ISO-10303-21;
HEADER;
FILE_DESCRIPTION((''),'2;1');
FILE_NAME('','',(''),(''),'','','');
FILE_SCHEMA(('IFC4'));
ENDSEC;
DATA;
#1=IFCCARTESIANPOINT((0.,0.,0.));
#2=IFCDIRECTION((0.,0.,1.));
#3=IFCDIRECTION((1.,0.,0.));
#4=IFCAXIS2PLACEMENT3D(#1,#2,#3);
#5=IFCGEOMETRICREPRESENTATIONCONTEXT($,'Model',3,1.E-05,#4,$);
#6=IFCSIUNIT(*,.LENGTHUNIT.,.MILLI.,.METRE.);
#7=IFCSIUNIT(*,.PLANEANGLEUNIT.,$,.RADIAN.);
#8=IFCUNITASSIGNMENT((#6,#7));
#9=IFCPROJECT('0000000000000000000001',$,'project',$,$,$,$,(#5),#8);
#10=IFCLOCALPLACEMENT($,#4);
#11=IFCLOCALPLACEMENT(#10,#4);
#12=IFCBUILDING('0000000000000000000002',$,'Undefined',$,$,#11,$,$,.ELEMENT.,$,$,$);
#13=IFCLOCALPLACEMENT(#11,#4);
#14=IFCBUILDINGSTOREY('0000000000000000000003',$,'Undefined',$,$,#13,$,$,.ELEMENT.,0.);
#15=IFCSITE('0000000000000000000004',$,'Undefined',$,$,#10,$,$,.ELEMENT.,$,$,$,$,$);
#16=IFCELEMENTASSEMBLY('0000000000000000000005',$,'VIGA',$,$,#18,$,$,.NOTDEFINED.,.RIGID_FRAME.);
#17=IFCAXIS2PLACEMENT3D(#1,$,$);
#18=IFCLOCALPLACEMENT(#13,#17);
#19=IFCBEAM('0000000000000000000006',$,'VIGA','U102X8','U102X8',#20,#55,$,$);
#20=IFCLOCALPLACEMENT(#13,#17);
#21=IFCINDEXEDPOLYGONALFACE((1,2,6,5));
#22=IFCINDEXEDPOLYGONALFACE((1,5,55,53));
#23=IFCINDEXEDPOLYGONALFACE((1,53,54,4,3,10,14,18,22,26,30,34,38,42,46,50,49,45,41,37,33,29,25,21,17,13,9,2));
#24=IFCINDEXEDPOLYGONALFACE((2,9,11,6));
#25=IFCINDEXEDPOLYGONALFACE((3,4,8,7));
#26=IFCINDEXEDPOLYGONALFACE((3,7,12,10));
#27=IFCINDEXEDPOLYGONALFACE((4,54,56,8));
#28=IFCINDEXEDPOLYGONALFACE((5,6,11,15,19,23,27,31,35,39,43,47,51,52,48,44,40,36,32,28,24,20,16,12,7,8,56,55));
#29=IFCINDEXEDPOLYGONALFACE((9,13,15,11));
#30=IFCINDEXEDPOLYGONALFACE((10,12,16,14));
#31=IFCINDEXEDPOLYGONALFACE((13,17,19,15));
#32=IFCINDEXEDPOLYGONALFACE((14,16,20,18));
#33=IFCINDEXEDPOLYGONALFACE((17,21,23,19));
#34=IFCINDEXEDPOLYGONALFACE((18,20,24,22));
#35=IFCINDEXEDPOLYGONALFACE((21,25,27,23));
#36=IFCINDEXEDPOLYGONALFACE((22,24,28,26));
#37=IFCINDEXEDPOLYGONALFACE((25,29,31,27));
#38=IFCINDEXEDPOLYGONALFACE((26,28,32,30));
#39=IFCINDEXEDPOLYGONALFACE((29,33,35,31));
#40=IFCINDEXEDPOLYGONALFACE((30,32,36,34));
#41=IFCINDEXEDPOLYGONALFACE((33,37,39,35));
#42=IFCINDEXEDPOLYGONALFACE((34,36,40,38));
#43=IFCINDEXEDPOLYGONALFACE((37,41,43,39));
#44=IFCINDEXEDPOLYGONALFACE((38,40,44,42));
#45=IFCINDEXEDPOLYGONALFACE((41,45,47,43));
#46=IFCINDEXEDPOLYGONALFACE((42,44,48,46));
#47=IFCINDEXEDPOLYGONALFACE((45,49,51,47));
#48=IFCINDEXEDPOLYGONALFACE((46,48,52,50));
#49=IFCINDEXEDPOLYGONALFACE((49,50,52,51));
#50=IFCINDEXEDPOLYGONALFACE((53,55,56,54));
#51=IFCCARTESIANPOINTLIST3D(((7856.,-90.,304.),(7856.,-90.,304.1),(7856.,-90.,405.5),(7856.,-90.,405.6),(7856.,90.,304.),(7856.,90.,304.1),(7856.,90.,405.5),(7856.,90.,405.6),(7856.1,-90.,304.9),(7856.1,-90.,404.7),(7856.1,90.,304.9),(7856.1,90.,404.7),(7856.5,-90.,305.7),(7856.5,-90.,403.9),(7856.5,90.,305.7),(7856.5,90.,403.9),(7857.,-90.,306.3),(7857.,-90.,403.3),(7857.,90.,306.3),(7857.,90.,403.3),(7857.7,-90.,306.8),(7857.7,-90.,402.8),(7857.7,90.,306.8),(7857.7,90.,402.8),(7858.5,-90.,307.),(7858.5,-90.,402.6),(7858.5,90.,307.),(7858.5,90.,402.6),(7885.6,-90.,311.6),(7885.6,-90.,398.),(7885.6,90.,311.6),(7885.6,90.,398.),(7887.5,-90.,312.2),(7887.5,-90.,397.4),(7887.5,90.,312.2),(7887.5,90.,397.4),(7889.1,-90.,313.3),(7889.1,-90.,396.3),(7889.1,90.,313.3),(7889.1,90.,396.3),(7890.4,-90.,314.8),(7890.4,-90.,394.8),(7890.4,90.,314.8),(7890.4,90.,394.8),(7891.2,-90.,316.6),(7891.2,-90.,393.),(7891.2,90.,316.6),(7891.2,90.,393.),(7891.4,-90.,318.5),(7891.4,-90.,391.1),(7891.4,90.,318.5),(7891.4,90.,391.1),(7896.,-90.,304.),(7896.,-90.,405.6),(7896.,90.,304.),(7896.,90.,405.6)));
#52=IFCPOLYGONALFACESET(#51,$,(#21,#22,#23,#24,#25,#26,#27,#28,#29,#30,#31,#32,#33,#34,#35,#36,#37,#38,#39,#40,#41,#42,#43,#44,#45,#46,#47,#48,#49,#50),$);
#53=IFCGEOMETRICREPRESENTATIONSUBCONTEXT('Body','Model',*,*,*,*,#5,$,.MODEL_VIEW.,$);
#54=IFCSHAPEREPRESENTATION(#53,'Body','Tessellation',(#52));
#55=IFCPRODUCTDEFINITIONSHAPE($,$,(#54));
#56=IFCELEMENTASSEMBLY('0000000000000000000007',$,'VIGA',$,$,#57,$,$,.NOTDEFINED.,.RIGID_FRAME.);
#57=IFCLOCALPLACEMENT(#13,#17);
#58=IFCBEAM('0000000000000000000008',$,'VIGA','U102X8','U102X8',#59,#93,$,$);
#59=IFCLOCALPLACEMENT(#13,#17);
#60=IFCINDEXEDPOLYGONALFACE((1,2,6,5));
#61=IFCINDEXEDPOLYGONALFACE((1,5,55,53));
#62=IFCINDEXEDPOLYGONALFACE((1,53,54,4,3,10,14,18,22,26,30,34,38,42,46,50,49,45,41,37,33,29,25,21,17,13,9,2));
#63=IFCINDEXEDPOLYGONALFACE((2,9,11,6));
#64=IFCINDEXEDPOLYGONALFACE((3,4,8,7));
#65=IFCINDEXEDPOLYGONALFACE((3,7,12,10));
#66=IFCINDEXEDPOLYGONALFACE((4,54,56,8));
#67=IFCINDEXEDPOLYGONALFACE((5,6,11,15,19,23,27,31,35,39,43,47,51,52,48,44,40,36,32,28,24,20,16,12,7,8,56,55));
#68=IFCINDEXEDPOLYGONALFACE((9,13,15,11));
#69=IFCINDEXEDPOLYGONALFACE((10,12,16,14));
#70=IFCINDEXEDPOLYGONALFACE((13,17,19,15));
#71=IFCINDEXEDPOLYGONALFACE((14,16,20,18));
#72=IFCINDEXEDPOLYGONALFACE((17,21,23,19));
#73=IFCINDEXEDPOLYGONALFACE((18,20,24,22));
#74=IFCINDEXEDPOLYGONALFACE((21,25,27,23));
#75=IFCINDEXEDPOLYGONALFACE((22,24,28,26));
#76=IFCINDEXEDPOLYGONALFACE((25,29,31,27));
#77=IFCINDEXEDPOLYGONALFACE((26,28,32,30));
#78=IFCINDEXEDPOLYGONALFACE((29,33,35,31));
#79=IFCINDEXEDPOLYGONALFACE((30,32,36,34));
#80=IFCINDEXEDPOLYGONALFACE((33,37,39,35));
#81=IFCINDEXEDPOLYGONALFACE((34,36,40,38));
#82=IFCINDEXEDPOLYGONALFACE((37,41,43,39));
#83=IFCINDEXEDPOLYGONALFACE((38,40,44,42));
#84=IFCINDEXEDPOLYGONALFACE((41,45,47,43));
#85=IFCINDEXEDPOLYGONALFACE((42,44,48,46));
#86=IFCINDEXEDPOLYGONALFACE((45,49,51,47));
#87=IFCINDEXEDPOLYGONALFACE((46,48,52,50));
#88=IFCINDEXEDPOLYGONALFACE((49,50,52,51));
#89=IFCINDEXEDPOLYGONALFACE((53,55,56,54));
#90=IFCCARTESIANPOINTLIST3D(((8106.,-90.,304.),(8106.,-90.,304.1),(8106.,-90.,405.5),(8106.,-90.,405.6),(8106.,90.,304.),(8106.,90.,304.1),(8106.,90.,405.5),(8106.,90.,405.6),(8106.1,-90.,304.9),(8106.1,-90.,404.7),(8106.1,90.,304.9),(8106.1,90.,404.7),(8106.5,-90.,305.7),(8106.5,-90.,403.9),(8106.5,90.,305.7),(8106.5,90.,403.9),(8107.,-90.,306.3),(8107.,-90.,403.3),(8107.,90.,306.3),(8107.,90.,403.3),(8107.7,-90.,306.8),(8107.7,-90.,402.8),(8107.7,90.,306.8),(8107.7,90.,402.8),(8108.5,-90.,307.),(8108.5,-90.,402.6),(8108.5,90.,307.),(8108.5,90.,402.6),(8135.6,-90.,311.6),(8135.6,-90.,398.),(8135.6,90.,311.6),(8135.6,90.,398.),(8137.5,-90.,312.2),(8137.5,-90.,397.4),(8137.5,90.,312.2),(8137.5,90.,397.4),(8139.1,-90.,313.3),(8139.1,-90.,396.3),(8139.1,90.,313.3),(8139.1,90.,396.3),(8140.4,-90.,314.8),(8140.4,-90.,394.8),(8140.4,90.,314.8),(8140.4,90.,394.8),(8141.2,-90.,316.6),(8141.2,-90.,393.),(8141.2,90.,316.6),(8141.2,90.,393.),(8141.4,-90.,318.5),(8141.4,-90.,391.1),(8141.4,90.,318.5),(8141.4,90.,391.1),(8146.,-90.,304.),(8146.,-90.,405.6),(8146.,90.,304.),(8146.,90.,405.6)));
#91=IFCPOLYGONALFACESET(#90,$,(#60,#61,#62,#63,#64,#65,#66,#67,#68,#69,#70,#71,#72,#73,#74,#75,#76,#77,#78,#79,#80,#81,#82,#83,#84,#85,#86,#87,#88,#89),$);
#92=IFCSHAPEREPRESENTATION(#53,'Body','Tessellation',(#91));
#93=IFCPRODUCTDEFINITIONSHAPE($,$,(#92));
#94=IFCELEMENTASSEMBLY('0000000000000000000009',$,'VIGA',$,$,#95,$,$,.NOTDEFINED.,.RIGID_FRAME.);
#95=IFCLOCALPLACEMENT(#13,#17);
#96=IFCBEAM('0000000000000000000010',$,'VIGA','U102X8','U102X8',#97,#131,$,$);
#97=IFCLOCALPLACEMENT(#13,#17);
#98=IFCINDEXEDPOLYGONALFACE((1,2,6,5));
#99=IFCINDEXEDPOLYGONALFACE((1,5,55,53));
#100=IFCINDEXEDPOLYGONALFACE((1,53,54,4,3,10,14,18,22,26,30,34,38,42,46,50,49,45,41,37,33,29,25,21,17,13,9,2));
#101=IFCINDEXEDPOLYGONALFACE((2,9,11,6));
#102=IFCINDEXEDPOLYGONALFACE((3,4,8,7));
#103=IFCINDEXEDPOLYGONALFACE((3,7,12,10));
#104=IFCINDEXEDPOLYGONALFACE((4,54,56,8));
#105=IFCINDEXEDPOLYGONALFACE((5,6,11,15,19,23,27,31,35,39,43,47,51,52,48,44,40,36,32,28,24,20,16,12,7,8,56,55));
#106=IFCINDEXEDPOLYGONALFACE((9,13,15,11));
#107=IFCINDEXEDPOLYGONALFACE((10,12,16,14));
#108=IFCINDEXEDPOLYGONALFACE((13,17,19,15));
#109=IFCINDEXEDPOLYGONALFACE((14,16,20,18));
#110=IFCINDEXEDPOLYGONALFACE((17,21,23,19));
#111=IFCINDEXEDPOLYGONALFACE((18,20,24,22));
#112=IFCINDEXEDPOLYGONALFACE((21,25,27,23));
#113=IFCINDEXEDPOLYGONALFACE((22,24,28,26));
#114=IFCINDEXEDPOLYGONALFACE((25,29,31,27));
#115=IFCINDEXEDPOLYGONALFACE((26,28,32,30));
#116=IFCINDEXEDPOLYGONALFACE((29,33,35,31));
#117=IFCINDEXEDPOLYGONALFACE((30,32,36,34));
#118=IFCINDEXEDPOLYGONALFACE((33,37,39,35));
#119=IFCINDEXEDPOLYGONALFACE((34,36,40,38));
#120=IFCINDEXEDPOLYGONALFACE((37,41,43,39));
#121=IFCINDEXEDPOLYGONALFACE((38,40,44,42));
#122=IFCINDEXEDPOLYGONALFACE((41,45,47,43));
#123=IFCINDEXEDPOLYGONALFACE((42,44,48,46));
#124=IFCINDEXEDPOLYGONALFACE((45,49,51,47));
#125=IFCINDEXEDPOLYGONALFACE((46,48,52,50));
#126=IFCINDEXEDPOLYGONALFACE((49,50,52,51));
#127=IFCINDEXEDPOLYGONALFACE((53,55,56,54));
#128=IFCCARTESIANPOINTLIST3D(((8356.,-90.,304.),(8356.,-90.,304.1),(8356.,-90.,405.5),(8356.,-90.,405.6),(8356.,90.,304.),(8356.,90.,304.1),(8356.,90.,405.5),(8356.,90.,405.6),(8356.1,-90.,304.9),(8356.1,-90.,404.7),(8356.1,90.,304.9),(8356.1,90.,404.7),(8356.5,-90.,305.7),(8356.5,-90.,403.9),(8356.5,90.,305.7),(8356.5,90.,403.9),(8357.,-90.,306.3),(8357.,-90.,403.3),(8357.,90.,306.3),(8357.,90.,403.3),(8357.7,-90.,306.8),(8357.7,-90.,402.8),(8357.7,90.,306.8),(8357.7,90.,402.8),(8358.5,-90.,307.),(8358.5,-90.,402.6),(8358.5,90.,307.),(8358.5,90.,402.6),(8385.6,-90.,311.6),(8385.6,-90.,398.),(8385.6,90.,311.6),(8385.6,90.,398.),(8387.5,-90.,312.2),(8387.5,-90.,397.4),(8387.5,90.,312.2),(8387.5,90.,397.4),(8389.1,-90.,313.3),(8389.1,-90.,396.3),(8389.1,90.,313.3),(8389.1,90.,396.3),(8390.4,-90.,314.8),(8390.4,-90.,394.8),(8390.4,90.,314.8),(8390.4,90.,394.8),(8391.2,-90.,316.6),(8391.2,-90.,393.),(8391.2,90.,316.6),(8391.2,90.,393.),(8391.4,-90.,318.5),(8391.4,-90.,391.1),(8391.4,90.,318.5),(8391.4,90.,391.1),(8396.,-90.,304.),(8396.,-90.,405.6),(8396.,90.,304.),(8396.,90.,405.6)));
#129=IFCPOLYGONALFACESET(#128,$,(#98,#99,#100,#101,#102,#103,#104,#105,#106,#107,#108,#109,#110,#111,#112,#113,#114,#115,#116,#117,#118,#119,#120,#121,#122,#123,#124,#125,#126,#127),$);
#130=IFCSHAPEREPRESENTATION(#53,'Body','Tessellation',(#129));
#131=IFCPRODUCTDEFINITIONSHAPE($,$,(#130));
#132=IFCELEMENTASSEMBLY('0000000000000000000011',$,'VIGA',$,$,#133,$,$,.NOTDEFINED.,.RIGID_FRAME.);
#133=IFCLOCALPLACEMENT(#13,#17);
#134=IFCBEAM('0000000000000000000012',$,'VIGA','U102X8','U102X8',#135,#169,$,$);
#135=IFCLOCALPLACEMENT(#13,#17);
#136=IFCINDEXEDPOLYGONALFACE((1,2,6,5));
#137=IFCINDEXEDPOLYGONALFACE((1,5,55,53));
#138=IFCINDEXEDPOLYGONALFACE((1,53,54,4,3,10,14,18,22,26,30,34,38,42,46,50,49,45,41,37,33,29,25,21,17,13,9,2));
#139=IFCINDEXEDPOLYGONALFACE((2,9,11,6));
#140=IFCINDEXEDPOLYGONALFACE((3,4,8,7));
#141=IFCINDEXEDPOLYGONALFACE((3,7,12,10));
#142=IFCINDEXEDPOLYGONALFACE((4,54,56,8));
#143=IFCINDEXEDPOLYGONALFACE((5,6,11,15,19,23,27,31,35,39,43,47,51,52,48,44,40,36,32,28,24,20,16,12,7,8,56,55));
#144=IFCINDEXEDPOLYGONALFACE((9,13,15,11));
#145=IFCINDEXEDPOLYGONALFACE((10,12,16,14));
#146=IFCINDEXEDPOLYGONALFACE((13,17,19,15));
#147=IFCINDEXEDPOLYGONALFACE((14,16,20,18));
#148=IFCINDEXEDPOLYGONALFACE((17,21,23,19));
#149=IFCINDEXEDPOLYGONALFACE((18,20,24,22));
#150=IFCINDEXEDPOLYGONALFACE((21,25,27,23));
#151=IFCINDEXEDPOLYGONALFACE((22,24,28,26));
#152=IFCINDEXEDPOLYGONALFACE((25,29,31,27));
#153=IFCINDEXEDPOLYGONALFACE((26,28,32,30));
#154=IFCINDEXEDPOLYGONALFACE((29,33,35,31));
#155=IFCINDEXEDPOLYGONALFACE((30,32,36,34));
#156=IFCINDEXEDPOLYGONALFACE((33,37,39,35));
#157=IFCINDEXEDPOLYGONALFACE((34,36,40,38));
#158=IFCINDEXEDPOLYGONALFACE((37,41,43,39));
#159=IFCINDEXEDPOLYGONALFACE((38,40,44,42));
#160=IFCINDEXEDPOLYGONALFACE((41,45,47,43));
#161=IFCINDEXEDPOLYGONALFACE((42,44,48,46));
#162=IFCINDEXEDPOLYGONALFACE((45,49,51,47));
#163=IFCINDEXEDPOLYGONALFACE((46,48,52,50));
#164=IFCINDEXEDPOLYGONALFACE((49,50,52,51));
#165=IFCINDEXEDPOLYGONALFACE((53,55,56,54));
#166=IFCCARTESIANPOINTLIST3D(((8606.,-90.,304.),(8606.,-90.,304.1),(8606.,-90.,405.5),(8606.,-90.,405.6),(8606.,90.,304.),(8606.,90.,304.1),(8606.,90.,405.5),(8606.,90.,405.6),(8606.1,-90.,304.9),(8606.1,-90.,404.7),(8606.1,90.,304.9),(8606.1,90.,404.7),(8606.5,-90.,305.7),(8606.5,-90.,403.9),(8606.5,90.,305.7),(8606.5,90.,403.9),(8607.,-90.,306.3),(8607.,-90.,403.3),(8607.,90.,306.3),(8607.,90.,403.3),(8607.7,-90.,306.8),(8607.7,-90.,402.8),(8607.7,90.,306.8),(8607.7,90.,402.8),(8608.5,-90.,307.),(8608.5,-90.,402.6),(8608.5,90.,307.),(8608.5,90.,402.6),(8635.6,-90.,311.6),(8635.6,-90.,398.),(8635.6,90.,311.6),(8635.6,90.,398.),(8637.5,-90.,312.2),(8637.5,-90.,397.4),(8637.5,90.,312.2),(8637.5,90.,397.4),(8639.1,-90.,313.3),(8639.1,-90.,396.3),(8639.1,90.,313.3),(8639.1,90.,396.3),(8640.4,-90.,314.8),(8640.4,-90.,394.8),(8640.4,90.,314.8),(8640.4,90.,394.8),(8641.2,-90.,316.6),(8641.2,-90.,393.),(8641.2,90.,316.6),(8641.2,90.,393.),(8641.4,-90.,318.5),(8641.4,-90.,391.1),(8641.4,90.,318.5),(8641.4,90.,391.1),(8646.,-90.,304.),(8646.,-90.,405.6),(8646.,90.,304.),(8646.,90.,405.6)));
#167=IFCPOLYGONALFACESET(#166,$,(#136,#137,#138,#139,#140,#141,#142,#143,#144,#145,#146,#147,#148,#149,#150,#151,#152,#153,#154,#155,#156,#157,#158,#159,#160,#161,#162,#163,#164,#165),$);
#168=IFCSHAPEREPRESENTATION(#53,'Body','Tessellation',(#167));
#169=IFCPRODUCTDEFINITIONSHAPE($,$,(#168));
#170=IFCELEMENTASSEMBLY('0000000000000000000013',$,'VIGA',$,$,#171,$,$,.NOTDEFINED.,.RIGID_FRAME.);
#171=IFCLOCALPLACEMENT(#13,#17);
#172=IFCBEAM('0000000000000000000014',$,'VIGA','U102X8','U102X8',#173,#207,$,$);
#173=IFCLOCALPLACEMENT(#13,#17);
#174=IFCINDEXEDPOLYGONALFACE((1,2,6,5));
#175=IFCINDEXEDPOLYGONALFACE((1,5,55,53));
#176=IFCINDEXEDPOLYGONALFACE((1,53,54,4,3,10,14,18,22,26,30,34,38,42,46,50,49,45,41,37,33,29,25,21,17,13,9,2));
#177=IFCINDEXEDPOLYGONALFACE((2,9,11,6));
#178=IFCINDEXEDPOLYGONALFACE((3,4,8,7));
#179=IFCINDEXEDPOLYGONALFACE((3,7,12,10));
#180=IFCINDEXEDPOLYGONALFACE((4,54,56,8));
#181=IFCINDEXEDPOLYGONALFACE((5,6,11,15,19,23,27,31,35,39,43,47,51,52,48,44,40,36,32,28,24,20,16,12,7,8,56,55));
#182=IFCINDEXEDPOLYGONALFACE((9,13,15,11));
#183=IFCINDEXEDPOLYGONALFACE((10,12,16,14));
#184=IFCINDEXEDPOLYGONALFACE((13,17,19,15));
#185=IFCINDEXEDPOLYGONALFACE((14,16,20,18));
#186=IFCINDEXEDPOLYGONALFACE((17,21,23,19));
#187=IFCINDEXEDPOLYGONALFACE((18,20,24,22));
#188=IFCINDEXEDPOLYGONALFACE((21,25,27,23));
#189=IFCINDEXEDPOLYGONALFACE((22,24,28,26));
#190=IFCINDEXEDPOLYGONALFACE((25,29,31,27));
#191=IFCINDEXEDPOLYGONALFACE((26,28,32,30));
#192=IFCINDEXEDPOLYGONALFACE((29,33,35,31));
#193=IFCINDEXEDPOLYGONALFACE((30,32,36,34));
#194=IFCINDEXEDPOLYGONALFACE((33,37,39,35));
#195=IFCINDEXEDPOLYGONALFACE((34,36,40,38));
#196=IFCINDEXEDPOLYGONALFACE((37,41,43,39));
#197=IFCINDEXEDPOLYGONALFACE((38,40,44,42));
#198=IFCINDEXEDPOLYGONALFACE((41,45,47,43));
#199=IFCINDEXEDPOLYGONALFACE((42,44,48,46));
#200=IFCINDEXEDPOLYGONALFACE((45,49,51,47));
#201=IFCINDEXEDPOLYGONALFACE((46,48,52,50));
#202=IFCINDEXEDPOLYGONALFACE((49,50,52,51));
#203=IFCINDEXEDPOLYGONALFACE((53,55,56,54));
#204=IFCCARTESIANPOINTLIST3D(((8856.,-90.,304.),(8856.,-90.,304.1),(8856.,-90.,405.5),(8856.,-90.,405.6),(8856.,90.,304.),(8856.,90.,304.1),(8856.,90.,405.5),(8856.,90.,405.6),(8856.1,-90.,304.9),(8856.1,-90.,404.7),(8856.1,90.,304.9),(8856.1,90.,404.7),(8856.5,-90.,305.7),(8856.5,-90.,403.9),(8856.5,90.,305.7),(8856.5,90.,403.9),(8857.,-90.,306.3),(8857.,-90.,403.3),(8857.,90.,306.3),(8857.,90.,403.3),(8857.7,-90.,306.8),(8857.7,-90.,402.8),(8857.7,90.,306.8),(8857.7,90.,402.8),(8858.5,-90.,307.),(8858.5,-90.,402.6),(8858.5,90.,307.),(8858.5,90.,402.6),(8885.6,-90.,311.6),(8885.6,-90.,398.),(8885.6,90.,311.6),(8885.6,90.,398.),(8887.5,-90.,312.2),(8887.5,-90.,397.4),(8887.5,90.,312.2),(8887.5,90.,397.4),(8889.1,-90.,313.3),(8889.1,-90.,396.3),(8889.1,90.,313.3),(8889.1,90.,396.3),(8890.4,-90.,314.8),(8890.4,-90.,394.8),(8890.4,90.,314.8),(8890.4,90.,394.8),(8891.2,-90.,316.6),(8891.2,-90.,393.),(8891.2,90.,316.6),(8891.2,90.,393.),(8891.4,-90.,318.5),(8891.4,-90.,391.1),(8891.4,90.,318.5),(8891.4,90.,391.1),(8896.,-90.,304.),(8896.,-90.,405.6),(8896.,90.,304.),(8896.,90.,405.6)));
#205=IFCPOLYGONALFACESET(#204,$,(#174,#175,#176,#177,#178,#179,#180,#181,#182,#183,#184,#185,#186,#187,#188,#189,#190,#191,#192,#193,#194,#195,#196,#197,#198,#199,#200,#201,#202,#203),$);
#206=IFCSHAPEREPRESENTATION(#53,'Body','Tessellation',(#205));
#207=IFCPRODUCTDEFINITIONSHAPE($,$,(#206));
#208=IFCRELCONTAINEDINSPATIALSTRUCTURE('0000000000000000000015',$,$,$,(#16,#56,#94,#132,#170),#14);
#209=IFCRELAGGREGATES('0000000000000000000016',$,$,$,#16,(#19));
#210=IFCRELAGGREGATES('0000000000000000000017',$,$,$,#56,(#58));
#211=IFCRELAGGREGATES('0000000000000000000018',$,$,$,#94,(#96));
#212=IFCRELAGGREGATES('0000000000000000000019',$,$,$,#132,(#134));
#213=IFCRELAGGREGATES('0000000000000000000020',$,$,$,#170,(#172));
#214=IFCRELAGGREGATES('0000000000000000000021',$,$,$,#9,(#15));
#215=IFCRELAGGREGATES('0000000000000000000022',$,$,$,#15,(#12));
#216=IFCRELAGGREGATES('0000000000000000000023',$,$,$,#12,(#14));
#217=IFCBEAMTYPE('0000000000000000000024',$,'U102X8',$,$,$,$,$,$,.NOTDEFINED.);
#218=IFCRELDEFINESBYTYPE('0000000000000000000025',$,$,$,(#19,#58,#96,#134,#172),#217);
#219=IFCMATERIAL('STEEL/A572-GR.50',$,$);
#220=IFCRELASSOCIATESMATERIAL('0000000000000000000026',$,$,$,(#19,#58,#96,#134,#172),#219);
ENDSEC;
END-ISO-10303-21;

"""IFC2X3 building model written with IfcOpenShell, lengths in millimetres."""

from ifc_helpers import new_model, si_unit, frame, origin_with_axes, origin_2d_with_axis, place, context, subcontext, project, spatial, u_section, extrude, material, type_object, element, aggregate, save


model = new_model("IFC2X3")

# Units and contexts
model_context = context("Model", 3, precision=1e-05, world=origin_with_axes())
body_context = subcontext(model_context, "Body", "Model", "MODEL_VIEW")
ifc_project = project(units=[si_unit("LENGTHUNIT", "METRE", prefix="MILLI"), si_unit("PLANEANGLEUNIT", "RADIAN")], contexts=[model_context])

# Site, building, storey
site_placement = place(None, origin_with_axes())
site = spatial("IfcSite", under=ifc_project, at=site_placement, Name="Undefined", CompositionType="ELEMENT")
building_placement = place(site_placement, origin_with_axes())
building = spatial("IfcBuilding", under=site, at=building_placement, Name="Undefined", CompositionType="ELEMENT")
storey_placement = place(building_placement, origin_with_axes())
storey = spatial("IfcBuildingStorey", under=building, at=storey_placement, Name="Undefined", CompositionType="ELEMENT", Elevation=0.0)

# Element assemblies, beams
ifc_material_1 = material(Name="STEEL/A572-GR.50")
beam_type_1 = type_object("IfcBeamType", Name="U102X8", PredefinedType="NOTDEFINED")
assembly_1_placement = place(storey_placement, origin_with_axes())
assembly_1 = element("IfcElementAssembly", 1, at=assembly_1_placement, inside=storey, Name="VIGA", AssemblyPlace="NOTDEFINED", PredefinedType="RIGID_FRAME")
beam_1_placement = place(assembly_1_placement, frame((7876.0, 90.0, 354.8), z_axis=(0.0, 0.0, 1.0), x_axis=(0.0, -1.0, 0.0)))
beam_1 = element("IfcBeam", 2, at=beam_1_placement, type_object=beam_type_1, material=ifc_material_1, Name="VIGA", Description="U102X8", ObjectType="U102X8", context=body_context, shape_type="SweptSolid", body=[
    extrude(u_section(Depth=101.6, FlangeWidth=40.0, WebThickness=4.6, FlangeThickness=6.0, FilletRadius=7.0, EdgeRadius=3.0, FlangeSlope=0.16839, at=origin_2d_with_axis()), frame((180.0, 0.0, 0.0), z_axis=(-1.0, 0.0, 0.0), x_axis=(0.0, -1.0, 0.0)), (0.0, 0.0, 1.0), 180.0),
])
aggregate(assembly_1, [beam_1])
assembly_2_placement = place(storey_placement, origin_with_axes())
assembly_2 = element("IfcElementAssembly", 3, at=assembly_2_placement, inside=storey, Name="VIGA", AssemblyPlace="NOTDEFINED", PredefinedType="RIGID_FRAME")
beam_2_placement = place(assembly_2_placement, frame((8126.0, 90.0, 354.8), z_axis=(0.0, 0.0, 1.0), x_axis=(0.0, -1.0, 0.0)))
beam_2 = element("IfcBeam", 4, at=beam_2_placement, type_object=beam_type_1, material=ifc_material_1, Name="VIGA", Description="U102X8", ObjectType="U102X8", context=body_context, shape_type="SweptSolid", body=[
    extrude(u_section(Depth=101.6, FlangeWidth=40.0, WebThickness=4.6, FlangeThickness=6.0, FilletRadius=7.0, EdgeRadius=3.0, FlangeSlope=0.16839, at=origin_2d_with_axis()), frame((180.0, 0.0, 0.0), z_axis=(-1.0, 0.0, 0.0), x_axis=(0.0, -1.0, 0.0)), (0.0, 0.0, 1.0), 180.0),
])
aggregate(assembly_2, [beam_2])
assembly_3_placement = place(storey_placement, origin_with_axes())
assembly_3 = element("IfcElementAssembly", 5, at=assembly_3_placement, inside=storey, Name="VIGA", AssemblyPlace="NOTDEFINED", PredefinedType="RIGID_FRAME")
beam_3_placement = place(assembly_3_placement, frame((8376.0, 90.0, 354.8), z_axis=(0.0, 0.0, 1.0), x_axis=(0.0, -1.0, 0.0)))
beam_3 = element("IfcBeam", 6, at=beam_3_placement, type_object=beam_type_1, material=ifc_material_1, Name="VIGA", Description="U102X8", ObjectType="U102X8", context=body_context, shape_type="SweptSolid", body=[
    extrude(u_section(Depth=101.6, FlangeWidth=40.0, WebThickness=4.6, FlangeThickness=6.0, FilletRadius=7.0, EdgeRadius=3.0, FlangeSlope=0.16839, at=origin_2d_with_axis()), frame((180.0, 0.0, 0.0), z_axis=(-1.0, 0.0, 0.0), x_axis=(0.0, -1.0, 0.0)), (0.0, 0.0, 1.0), 180.0),
])
aggregate(assembly_3, [beam_3])
assembly_4_placement = place(storey_placement, origin_with_axes())
assembly_4 = element("IfcElementAssembly", 7, at=assembly_4_placement, inside=storey, Name="VIGA", AssemblyPlace="NOTDEFINED", PredefinedType="RIGID_FRAME")
beam_4_placement = place(assembly_4_placement, frame((8626.0, 90.0, 354.8), z_axis=(0.0, 0.0, 1.0), x_axis=(0.0, -1.0, 0.0)))
beam_4 = element("IfcBeam", 8, at=beam_4_placement, type_object=beam_type_1, material=ifc_material_1, Name="VIGA", Description="U102X8", ObjectType="U102X8", context=body_context, shape_type="SweptSolid", body=[
    extrude(u_section(Depth=101.6, FlangeWidth=40.0, WebThickness=4.6, FlangeThickness=6.0, FilletRadius=7.0, EdgeRadius=3.0, FlangeSlope=0.16839, at=origin_2d_with_axis()), frame((180.0, 0.0, 0.0), z_axis=(-1.0, 0.0, 0.0), x_axis=(0.0, -1.0, 0.0)), (0.0, 0.0, 1.0), 180.0),
])
aggregate(assembly_4, [beam_4])
assembly_5_placement = place(storey_placement, origin_with_axes())
assembly_5 = element("IfcElementAssembly", 9, at=assembly_5_placement, inside=storey, Name="VIGA", AssemblyPlace="NOTDEFINED", PredefinedType="RIGID_FRAME")
beam_5_placement = place(assembly_5_placement, frame((8876.0, 90.0, 354.8), z_axis=(0.0, 0.0, 1.0), x_axis=(0.0, -1.0, 0.0)))
beam_5 = element("IfcBeam", 10, at=beam_5_placement, type_object=beam_type_1, material=ifc_material_1, Name="VIGA", Description="U102X8", ObjectType="U102X8", context=body_context, shape_type="SweptSolid", body=[
    extrude(u_section(Depth=101.6, FlangeWidth=40.0, WebThickness=4.6, FlangeThickness=6.0, FilletRadius=7.0, EdgeRadius=3.0, FlangeSlope=0.16839, at=origin_2d_with_axis()), frame((180.0, 0.0, 0.0), z_axis=(-1.0, 0.0, 0.0), x_axis=(0.0, -1.0, 0.0)), (0.0, 0.0, 1.0), 180.0),
])
aggregate(assembly_5, [beam_5])

save(model, "model.ifc")
